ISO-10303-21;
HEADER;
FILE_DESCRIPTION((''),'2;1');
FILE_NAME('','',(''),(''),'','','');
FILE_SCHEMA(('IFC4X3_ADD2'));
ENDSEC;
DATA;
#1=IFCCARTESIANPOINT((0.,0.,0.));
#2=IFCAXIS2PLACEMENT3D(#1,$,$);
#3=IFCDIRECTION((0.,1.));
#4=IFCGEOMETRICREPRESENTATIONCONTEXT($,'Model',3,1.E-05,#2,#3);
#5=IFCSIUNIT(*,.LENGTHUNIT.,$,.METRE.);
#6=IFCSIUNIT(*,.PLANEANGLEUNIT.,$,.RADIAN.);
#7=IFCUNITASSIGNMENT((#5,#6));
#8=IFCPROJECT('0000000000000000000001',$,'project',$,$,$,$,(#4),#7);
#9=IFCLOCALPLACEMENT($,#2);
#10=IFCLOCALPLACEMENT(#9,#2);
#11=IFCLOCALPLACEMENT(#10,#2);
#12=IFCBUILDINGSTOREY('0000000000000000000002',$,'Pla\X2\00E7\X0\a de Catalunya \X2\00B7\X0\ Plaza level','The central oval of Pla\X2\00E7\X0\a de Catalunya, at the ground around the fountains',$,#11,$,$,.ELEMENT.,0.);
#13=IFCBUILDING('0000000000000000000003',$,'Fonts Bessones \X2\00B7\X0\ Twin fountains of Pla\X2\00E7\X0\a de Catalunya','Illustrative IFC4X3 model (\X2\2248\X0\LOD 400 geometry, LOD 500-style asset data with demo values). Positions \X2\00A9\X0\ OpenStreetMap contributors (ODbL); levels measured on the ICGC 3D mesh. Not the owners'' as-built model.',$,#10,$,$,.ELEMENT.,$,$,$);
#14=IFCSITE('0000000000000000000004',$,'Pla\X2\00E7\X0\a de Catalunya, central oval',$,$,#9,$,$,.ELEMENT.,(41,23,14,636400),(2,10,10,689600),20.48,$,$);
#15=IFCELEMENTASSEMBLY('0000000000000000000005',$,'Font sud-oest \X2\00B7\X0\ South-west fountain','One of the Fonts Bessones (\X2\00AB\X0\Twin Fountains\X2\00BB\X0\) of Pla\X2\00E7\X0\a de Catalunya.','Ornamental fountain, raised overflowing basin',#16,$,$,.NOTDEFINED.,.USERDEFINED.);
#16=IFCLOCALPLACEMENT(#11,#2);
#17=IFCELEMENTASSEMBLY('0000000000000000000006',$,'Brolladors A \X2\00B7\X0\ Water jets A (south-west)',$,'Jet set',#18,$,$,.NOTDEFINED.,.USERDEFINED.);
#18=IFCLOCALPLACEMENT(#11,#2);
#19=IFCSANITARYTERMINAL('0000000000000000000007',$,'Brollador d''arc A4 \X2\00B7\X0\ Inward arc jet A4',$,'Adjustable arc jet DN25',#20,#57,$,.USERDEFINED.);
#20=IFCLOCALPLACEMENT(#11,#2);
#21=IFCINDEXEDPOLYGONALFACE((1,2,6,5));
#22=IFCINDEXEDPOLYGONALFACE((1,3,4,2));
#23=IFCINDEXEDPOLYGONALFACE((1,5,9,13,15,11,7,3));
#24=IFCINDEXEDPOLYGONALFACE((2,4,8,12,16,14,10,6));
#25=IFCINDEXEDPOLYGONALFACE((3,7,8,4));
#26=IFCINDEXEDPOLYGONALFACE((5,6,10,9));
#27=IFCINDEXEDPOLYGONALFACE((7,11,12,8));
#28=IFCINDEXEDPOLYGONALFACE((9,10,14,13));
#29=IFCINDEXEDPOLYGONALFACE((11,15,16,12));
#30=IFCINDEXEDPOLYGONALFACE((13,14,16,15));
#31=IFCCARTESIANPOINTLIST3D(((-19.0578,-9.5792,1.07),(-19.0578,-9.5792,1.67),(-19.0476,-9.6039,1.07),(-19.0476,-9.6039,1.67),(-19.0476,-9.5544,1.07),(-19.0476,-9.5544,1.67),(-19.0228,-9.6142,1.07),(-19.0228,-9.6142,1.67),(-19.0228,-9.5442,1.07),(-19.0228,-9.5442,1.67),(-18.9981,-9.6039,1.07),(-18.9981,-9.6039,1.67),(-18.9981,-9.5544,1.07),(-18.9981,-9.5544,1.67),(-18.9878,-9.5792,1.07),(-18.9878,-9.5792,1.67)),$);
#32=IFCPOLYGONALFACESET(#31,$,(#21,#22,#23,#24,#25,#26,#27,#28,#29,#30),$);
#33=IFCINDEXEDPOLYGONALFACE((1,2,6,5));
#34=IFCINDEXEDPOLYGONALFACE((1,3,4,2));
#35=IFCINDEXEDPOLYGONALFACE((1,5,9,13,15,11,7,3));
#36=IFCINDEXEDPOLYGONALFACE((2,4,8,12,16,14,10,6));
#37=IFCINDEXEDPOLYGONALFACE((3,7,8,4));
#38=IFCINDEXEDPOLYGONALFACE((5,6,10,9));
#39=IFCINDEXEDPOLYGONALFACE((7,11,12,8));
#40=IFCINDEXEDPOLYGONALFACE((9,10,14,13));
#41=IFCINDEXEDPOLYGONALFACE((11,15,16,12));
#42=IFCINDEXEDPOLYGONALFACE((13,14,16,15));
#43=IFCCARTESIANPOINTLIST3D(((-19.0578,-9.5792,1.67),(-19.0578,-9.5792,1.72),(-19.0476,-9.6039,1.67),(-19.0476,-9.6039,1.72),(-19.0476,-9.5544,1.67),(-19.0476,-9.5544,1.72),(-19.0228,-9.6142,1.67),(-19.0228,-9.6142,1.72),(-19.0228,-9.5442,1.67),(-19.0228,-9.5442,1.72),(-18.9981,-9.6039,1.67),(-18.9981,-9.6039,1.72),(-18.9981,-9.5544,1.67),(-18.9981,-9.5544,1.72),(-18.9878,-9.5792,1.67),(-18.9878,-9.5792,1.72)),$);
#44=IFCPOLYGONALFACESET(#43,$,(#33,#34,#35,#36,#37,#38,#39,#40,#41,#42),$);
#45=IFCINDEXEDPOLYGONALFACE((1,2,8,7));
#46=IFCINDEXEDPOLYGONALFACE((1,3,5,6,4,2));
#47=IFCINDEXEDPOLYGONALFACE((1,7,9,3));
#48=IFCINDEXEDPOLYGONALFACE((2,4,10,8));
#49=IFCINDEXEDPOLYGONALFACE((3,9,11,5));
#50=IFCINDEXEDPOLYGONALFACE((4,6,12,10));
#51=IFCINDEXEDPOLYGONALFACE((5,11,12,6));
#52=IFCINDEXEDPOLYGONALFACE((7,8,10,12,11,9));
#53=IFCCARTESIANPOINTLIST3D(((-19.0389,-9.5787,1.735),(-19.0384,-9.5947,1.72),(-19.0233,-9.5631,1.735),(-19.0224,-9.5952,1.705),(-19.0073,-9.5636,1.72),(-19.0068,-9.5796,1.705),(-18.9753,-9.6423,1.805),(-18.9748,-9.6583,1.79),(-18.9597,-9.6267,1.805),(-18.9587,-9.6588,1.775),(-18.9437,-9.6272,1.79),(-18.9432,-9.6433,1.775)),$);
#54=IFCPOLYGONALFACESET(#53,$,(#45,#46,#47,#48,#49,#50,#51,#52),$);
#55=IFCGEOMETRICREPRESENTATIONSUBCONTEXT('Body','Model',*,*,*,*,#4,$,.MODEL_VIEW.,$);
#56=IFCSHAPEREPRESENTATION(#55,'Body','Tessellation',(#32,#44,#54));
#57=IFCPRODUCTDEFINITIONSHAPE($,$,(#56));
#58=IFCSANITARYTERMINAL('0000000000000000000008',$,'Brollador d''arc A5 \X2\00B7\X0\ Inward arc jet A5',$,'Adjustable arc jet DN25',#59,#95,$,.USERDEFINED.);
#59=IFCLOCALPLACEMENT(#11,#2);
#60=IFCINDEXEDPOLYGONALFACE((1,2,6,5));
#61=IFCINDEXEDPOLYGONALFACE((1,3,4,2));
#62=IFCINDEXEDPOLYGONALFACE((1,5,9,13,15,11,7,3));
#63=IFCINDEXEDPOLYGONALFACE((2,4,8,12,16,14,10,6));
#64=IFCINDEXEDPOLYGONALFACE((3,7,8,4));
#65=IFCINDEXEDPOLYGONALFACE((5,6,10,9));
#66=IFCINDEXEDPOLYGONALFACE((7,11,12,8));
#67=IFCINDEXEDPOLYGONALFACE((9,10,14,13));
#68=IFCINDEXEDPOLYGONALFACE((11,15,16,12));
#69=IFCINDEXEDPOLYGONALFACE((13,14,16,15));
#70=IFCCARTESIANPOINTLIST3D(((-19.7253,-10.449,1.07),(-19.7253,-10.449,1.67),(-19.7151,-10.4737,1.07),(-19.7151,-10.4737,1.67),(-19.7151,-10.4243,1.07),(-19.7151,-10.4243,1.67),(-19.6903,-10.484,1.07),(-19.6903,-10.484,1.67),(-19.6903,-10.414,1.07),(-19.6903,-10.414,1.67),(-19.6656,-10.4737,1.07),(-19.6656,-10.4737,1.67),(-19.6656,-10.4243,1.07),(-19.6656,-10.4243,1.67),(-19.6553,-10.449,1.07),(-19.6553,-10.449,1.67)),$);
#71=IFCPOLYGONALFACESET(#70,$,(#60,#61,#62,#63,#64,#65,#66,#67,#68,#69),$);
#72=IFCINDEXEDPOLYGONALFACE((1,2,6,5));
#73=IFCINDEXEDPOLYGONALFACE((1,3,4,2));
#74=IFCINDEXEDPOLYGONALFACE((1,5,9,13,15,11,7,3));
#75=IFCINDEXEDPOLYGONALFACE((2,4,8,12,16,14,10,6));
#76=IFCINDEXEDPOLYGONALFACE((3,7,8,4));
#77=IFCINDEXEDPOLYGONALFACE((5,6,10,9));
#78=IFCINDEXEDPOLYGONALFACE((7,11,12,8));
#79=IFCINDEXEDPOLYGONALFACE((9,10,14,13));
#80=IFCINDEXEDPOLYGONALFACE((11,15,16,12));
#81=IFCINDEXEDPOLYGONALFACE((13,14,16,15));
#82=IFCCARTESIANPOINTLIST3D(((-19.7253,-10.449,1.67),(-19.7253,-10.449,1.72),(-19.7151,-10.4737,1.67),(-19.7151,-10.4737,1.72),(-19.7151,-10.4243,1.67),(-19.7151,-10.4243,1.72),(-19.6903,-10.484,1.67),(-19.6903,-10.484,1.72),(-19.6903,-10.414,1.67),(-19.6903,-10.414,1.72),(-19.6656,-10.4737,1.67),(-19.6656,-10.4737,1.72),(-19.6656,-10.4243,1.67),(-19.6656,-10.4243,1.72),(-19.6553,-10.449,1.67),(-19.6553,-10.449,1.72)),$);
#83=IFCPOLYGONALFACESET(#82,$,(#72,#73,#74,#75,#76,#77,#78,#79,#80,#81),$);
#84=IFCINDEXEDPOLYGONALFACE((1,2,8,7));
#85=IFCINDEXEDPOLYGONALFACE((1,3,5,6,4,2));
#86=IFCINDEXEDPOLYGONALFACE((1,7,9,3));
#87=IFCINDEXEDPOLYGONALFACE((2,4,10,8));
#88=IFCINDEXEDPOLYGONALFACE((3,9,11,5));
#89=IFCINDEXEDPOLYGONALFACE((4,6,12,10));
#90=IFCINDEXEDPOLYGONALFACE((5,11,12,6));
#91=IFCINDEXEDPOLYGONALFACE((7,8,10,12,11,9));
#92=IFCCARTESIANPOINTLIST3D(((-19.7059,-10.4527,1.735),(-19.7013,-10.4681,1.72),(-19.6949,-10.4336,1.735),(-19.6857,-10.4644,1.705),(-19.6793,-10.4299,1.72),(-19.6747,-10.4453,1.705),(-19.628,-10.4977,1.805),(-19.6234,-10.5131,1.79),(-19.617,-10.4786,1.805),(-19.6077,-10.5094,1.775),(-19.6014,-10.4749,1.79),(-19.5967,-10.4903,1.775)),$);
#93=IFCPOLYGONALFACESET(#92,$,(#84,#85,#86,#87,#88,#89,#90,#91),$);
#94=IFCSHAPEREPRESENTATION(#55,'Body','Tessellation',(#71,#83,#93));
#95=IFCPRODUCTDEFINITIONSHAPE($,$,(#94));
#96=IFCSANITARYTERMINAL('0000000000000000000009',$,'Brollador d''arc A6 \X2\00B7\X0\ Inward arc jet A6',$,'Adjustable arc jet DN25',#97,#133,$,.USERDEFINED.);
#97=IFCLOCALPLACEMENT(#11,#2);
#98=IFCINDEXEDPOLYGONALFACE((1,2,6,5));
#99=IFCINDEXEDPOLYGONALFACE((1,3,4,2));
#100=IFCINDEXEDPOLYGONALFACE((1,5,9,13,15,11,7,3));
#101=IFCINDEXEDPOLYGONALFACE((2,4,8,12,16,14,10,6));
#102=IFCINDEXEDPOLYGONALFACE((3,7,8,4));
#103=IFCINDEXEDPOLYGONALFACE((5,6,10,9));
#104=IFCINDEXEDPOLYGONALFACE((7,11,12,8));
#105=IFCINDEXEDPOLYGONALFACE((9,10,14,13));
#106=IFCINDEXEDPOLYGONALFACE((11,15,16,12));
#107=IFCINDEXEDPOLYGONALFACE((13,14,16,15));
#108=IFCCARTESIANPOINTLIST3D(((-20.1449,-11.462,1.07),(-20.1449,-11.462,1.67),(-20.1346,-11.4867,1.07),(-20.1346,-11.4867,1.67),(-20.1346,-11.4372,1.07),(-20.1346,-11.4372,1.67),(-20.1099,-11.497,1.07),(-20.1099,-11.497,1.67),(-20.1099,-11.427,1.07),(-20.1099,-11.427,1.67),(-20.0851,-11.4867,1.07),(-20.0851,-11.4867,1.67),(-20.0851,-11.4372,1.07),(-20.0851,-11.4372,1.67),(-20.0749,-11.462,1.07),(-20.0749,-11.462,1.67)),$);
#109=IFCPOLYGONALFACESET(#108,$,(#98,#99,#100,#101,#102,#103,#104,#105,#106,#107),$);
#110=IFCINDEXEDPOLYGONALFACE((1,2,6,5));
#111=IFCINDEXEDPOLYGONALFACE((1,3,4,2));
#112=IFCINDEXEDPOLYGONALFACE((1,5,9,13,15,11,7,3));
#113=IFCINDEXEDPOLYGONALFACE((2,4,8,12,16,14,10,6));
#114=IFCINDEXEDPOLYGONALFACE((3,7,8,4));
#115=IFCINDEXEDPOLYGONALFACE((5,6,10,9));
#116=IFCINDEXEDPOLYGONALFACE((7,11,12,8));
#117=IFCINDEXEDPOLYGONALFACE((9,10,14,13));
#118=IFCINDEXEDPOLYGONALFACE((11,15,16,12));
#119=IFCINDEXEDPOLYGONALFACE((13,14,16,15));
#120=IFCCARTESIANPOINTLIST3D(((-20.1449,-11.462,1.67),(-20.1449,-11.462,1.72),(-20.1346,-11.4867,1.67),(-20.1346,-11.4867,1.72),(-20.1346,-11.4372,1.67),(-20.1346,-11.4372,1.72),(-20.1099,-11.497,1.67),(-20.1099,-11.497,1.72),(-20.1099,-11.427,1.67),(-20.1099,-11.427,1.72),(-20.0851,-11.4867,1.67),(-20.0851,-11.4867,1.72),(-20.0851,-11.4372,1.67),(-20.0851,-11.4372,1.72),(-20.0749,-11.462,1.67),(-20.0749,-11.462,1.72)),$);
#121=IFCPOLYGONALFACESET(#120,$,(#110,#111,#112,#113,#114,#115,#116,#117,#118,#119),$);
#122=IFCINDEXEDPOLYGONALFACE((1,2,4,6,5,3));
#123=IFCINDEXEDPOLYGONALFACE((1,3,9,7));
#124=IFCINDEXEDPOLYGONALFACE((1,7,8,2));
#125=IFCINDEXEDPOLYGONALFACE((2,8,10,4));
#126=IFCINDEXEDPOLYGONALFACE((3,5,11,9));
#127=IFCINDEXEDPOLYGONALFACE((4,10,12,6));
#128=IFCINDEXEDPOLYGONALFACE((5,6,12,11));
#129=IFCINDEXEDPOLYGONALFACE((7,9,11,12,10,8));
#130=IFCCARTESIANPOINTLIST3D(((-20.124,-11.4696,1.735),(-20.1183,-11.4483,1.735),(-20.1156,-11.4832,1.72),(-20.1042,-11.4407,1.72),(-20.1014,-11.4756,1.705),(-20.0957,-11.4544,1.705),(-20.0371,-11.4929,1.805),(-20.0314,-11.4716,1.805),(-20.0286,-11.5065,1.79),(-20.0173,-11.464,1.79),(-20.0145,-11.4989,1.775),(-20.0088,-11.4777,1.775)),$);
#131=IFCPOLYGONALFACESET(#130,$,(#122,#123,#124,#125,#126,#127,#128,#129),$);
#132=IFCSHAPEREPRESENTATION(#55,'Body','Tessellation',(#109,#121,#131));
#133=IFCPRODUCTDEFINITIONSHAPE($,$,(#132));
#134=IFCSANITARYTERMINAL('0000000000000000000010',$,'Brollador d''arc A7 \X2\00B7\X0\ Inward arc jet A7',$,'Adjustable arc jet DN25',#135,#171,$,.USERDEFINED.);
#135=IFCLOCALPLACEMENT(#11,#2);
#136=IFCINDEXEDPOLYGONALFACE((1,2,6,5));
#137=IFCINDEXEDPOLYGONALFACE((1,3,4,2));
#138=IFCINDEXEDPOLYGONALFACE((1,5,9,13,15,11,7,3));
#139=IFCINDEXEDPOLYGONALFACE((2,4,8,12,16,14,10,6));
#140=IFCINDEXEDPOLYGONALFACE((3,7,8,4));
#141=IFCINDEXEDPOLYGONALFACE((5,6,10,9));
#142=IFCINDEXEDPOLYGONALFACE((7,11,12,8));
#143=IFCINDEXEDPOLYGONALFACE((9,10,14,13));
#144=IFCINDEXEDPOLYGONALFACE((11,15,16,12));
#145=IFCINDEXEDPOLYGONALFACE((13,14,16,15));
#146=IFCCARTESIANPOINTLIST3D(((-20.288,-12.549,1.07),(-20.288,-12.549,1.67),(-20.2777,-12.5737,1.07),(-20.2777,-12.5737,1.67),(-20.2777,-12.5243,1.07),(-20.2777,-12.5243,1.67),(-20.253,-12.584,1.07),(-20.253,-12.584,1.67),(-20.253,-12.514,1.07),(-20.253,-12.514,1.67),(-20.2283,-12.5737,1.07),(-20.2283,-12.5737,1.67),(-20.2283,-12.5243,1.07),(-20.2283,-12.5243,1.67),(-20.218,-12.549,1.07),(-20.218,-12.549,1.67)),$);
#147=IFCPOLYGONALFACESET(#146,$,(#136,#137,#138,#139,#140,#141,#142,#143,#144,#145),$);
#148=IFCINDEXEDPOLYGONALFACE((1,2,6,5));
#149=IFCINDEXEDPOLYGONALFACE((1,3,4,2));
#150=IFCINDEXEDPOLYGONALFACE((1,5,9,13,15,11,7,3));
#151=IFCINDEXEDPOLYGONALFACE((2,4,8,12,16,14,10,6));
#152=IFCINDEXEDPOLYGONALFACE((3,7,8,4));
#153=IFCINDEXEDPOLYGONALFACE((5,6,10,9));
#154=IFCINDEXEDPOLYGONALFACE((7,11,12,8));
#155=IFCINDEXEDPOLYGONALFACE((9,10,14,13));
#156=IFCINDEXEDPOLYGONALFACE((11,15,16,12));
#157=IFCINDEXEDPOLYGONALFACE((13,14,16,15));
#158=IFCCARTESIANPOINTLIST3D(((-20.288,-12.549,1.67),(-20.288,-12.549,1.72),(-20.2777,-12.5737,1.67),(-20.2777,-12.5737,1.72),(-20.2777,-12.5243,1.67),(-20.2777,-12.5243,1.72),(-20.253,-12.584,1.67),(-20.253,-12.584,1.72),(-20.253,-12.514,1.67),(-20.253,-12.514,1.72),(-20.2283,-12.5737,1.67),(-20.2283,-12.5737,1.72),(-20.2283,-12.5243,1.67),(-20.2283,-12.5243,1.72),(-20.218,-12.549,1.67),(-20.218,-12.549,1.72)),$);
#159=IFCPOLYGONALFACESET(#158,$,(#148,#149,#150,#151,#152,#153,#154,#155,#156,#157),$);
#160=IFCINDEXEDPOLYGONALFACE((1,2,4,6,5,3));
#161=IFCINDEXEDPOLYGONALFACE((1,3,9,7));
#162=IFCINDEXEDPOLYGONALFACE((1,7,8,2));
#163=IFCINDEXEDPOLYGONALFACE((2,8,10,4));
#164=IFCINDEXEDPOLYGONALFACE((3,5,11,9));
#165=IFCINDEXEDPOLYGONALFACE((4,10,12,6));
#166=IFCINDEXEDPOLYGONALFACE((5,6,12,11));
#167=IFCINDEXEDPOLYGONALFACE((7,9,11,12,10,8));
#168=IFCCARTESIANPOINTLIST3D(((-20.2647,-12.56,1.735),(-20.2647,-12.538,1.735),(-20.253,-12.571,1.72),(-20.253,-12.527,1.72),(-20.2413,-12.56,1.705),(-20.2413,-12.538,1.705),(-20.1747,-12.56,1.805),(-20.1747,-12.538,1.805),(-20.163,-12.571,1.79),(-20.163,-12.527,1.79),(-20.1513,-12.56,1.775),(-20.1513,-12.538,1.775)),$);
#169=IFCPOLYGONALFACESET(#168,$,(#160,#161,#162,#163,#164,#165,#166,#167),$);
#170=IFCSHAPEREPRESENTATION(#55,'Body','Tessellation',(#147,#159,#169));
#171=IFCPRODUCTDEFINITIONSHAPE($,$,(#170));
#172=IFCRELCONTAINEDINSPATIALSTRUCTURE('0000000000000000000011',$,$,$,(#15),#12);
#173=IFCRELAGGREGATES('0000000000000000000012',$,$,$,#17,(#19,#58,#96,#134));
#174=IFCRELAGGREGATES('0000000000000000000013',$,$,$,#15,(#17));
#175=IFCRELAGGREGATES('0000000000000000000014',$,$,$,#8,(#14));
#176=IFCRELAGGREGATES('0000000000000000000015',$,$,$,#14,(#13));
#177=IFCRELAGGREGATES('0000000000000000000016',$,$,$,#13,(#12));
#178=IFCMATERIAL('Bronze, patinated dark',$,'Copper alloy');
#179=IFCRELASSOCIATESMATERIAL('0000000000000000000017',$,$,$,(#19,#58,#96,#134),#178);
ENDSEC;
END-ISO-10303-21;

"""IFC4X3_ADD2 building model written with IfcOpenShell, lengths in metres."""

from ifc_helpers import new_model, si_unit, direction, frame, origin, place, context, subcontext, project, spatial, polyline, outline, extrude, material, element, aggregate, save


model = new_model("IFC4X3_ADD2")

# Units and contexts
model_context = context("Model", 3, precision=1e-05, world=origin(), true_north=direction((0.0, 1.0)))
body_context = subcontext(model_context, "Body", "Model", "MODEL_VIEW")
ifc_project = project(units=[si_unit("LENGTHUNIT", "METRE"), si_unit("PLANEANGLEUNIT", "RADIAN")], contexts=[model_context])

# Site, building, storey
site_placement = place(None, origin())
site = spatial("IfcSite", under=ifc_project, at=site_placement, Name="Plaça de Catalunya, central oval", CompositionType="ELEMENT", RefLatitude=(41, 23, 14, 636400), RefLongitude=(2, 10, 10, 689600), RefElevation=20.48)
building_placement = place(site_placement, origin())
building = spatial("IfcBuilding", under=site, at=building_placement, Name="Fonts Bessones · Twin fountains of Plaça de Catalunya", Description="Illustrative IFC4X3 model (≈LOD 400 geometry, LOD 500-style asset data with demo values). Positions © OpenStreetMap contributors (ODbL); levels measured on the ICGC 3D mesh. Not the owners' as-built model.", CompositionType="ELEMENT")
storey_placement = place(building_placement, origin())
storey = spatial("IfcBuildingStorey", under=building, at=storey_placement, Name="Plaça de Catalunya · Plaza level", Description="The central oval of Plaça de Catalunya, at the ground around the fountains", CompositionType="ELEMENT", Elevation=0.0)

# Element assemblies, sanitary terminals
assembly_1_placement = place(building_placement, origin())
assembly_1 = element("IfcElementAssembly", 1, at=assembly_1_placement, inside=storey, Name="Font sud-oest · South-west fountain", Description="One of the Fonts Bessones («Twin Fountains») of Plaça de Catalunya.", ObjectType="Ornamental fountain, raised overflowing basin", AssemblyPlace="NOTDEFINED", PredefinedType="USERDEFINED")
assembly_2_placement = place(building_placement, origin())
assembly_2 = element("IfcElementAssembly", 2, at=assembly_2_placement, Name="Brolladors A · Water jets A (south-west)", ObjectType="Jet set", AssemblyPlace="NOTDEFINED", PredefinedType="USERDEFINED")
ifc_material_1 = material(Name="Bronze, patinated dark", Category="Copper alloy")
sanitary_terminal_1_placement = place(building_placement, origin())
sanitary_terminal_1 = element("IfcSanitaryTerminal", 3, at=sanitary_terminal_1_placement, material=ifc_material_1, Name="Brollador d'arc A4 · Inward arc jet A4", ObjectType="Adjustable arc jet DN25", PredefinedType="USERDEFINED", context=body_context, shape_type="SweptSolid", body=[
    extrude(outline(polyline([(-18.9878, -9.5792), (-18.9981, -9.5544), (-19.0228, -9.5442), (-19.0476, -9.5544), (-19.0578, -9.5792), (-19.0476, -9.6039), (-19.0228, -9.6142), (-18.9981, -9.6039), (-18.9878, -9.5792)])), frame((0.0, 0.0, 1.07)), (0.0, 0.0, 1.0), 0.6),
    extrude(outline(polyline([(-18.9878, -9.5792), (-18.9981, -9.5544), (-19.0228, -9.5442), (-19.0476, -9.5544), (-19.0578, -9.5792), (-19.0476, -9.6039), (-19.0228, -9.6142), (-18.9981, -9.6039), (-18.9878, -9.5792)])), frame((0.0, 0.0, 1.67)), (0.0, 0.0, 1.0), 0.05),
    extrude(outline(polyline([(0.022, 0.0), (0.011, 0.0191), (-0.011, 0.0191), (-0.022, 0.0), (-0.011, -0.0191), (0.011, -0.0191), (0.022, 0.0)])), frame((-19.0228, -9.5792, 1.72), z_axis=(0.558156, -0.558156, 0.613941), x_axis=(-0.707107, -0.707107, 0.0)), (0.0, 0.0, 1.0), 0.114),
])
sanitary_terminal_2_placement = place(building_placement, origin())
sanitary_terminal_2 = element("IfcSanitaryTerminal", 4, at=sanitary_terminal_2_placement, material=ifc_material_1, Name="Brollador d'arc A5 · Inward arc jet A5", ObjectType="Adjustable arc jet DN25", PredefinedType="USERDEFINED", context=body_context, shape_type="SweptSolid", body=[
    extrude(outline(polyline([(-19.6553, -10.449), (-19.6656, -10.4243), (-19.6903, -10.414), (-19.7151, -10.4243), (-19.7253, -10.449), (-19.7151, -10.4737), (-19.6903, -10.484), (-19.6656, -10.4737), (-19.6553, -10.449)])), frame((0.0, 0.0, 1.07)), (0.0, 0.0, 1.0), 0.6),
    extrude(outline(polyline([(-19.6553, -10.449), (-19.6656, -10.4243), (-19.6903, -10.414), (-19.7151, -10.4243), (-19.7253, -10.449), (-19.7151, -10.4737), (-19.6903, -10.484), (-19.6656, -10.4737), (-19.6553, -10.449)])), frame((0.0, 0.0, 1.67)), (0.0, 0.0, 1.0), 0.05),
    extrude(outline(polyline([(0.022, 0.0), (0.011, 0.0191), (-0.011, 0.0191), (-0.022, 0.0), (-0.011, -0.0191), (0.011, -0.0191), (0.022, 0.0)])), frame((-19.6903, -10.449, 1.72), z_axis=(0.683599, -0.394676, 0.613941), x_axis=(-0.5, -0.866025, 0.0)), (0.0, 0.0, 1.0), 0.114),
])
sanitary_terminal_3_placement = place(building_placement, origin())
sanitary_terminal_3 = element("IfcSanitaryTerminal", 5, at=sanitary_terminal_3_placement, material=ifc_material_1, Name="Brollador d'arc A6 · Inward arc jet A6", ObjectType="Adjustable arc jet DN25", PredefinedType="USERDEFINED", context=body_context, shape_type="SweptSolid", body=[
    extrude(outline(polyline([(-20.0749, -11.462), (-20.0851, -11.4372), (-20.1099, -11.427), (-20.1346, -11.4372), (-20.1449, -11.462), (-20.1346, -11.4867), (-20.1099, -11.497), (-20.0851, -11.4867), (-20.0749, -11.462)])), frame((0.0, 0.0, 1.07)), (0.0, 0.0, 1.0), 0.6),
    extrude(outline(polyline([(-20.0749, -11.462), (-20.0851, -11.4372), (-20.1099, -11.427), (-20.1346, -11.4372), (-20.1449, -11.462), (-20.1346, -11.4867), (-20.1099, -11.497), (-20.0851, -11.4867), (-20.0749, -11.462)])), frame((0.0, 0.0, 1.67)), (0.0, 0.0, 1.0), 0.05),
    extrude(outline(polyline([(0.022, 0.0), (0.011, 0.0191), (-0.011, 0.0191), (-0.022, 0.0), (-0.011, -0.0191), (0.011, -0.0191), (0.022, 0.0)])), frame((-20.1099, -11.462, 1.72), z_axis=(0.762456, -0.204299, 0.613941), x_axis=(-0.258819, -0.965926, 0.0)), (0.0, 0.0, 1.0), 0.114),
])
sanitary_terminal_4_placement = place(building_placement, origin())
sanitary_terminal_4 = element("IfcSanitaryTerminal", 6, at=sanitary_terminal_4_placement, material=ifc_material_1, Name="Brollador d'arc A7 · Inward arc jet A7", ObjectType="Adjustable arc jet DN25", PredefinedType="USERDEFINED", context=body_context, shape_type="SweptSolid", body=[
    extrude(outline(polyline([(-20.218, -12.549), (-20.2283, -12.5243), (-20.253, -12.514), (-20.2777, -12.5243), (-20.288, -12.549), (-20.2777, -12.5737), (-20.253, -12.584), (-20.2283, -12.5737), (-20.218, -12.549)])), frame((0.0, 0.0, 1.07)), (0.0, 0.0, 1.0), 0.6),
    extrude(outline(polyline([(-20.218, -12.549), (-20.2283, -12.5243), (-20.253, -12.514), (-20.2777, -12.5243), (-20.288, -12.549), (-20.2777, -12.5737), (-20.253, -12.584), (-20.2283, -12.5737), (-20.218, -12.549)])), frame((0.0, 0.0, 1.67)), (0.0, 0.0, 1.0), 0.05),
    extrude(outline(polyline([(0.022, 0.0), (0.011, 0.0191), (-0.011, 0.0191), (-0.022, 0.0), (-0.011, -0.0191), (0.011, -0.0191), (0.022, 0.0)])), frame((-20.253, -12.549, 1.72), z_axis=(0.789352, 0.0, 0.613941), x_axis=(0.0, -1.0, 0.0)), (0.0, 0.0, 1.0), 0.114),
])
aggregate(assembly_2, [sanitary_terminal_1, sanitary_terminal_2, sanitary_terminal_3, sanitary_terminal_4])
aggregate(assembly_1, [assembly_2])

save(model, "model.ifc")
